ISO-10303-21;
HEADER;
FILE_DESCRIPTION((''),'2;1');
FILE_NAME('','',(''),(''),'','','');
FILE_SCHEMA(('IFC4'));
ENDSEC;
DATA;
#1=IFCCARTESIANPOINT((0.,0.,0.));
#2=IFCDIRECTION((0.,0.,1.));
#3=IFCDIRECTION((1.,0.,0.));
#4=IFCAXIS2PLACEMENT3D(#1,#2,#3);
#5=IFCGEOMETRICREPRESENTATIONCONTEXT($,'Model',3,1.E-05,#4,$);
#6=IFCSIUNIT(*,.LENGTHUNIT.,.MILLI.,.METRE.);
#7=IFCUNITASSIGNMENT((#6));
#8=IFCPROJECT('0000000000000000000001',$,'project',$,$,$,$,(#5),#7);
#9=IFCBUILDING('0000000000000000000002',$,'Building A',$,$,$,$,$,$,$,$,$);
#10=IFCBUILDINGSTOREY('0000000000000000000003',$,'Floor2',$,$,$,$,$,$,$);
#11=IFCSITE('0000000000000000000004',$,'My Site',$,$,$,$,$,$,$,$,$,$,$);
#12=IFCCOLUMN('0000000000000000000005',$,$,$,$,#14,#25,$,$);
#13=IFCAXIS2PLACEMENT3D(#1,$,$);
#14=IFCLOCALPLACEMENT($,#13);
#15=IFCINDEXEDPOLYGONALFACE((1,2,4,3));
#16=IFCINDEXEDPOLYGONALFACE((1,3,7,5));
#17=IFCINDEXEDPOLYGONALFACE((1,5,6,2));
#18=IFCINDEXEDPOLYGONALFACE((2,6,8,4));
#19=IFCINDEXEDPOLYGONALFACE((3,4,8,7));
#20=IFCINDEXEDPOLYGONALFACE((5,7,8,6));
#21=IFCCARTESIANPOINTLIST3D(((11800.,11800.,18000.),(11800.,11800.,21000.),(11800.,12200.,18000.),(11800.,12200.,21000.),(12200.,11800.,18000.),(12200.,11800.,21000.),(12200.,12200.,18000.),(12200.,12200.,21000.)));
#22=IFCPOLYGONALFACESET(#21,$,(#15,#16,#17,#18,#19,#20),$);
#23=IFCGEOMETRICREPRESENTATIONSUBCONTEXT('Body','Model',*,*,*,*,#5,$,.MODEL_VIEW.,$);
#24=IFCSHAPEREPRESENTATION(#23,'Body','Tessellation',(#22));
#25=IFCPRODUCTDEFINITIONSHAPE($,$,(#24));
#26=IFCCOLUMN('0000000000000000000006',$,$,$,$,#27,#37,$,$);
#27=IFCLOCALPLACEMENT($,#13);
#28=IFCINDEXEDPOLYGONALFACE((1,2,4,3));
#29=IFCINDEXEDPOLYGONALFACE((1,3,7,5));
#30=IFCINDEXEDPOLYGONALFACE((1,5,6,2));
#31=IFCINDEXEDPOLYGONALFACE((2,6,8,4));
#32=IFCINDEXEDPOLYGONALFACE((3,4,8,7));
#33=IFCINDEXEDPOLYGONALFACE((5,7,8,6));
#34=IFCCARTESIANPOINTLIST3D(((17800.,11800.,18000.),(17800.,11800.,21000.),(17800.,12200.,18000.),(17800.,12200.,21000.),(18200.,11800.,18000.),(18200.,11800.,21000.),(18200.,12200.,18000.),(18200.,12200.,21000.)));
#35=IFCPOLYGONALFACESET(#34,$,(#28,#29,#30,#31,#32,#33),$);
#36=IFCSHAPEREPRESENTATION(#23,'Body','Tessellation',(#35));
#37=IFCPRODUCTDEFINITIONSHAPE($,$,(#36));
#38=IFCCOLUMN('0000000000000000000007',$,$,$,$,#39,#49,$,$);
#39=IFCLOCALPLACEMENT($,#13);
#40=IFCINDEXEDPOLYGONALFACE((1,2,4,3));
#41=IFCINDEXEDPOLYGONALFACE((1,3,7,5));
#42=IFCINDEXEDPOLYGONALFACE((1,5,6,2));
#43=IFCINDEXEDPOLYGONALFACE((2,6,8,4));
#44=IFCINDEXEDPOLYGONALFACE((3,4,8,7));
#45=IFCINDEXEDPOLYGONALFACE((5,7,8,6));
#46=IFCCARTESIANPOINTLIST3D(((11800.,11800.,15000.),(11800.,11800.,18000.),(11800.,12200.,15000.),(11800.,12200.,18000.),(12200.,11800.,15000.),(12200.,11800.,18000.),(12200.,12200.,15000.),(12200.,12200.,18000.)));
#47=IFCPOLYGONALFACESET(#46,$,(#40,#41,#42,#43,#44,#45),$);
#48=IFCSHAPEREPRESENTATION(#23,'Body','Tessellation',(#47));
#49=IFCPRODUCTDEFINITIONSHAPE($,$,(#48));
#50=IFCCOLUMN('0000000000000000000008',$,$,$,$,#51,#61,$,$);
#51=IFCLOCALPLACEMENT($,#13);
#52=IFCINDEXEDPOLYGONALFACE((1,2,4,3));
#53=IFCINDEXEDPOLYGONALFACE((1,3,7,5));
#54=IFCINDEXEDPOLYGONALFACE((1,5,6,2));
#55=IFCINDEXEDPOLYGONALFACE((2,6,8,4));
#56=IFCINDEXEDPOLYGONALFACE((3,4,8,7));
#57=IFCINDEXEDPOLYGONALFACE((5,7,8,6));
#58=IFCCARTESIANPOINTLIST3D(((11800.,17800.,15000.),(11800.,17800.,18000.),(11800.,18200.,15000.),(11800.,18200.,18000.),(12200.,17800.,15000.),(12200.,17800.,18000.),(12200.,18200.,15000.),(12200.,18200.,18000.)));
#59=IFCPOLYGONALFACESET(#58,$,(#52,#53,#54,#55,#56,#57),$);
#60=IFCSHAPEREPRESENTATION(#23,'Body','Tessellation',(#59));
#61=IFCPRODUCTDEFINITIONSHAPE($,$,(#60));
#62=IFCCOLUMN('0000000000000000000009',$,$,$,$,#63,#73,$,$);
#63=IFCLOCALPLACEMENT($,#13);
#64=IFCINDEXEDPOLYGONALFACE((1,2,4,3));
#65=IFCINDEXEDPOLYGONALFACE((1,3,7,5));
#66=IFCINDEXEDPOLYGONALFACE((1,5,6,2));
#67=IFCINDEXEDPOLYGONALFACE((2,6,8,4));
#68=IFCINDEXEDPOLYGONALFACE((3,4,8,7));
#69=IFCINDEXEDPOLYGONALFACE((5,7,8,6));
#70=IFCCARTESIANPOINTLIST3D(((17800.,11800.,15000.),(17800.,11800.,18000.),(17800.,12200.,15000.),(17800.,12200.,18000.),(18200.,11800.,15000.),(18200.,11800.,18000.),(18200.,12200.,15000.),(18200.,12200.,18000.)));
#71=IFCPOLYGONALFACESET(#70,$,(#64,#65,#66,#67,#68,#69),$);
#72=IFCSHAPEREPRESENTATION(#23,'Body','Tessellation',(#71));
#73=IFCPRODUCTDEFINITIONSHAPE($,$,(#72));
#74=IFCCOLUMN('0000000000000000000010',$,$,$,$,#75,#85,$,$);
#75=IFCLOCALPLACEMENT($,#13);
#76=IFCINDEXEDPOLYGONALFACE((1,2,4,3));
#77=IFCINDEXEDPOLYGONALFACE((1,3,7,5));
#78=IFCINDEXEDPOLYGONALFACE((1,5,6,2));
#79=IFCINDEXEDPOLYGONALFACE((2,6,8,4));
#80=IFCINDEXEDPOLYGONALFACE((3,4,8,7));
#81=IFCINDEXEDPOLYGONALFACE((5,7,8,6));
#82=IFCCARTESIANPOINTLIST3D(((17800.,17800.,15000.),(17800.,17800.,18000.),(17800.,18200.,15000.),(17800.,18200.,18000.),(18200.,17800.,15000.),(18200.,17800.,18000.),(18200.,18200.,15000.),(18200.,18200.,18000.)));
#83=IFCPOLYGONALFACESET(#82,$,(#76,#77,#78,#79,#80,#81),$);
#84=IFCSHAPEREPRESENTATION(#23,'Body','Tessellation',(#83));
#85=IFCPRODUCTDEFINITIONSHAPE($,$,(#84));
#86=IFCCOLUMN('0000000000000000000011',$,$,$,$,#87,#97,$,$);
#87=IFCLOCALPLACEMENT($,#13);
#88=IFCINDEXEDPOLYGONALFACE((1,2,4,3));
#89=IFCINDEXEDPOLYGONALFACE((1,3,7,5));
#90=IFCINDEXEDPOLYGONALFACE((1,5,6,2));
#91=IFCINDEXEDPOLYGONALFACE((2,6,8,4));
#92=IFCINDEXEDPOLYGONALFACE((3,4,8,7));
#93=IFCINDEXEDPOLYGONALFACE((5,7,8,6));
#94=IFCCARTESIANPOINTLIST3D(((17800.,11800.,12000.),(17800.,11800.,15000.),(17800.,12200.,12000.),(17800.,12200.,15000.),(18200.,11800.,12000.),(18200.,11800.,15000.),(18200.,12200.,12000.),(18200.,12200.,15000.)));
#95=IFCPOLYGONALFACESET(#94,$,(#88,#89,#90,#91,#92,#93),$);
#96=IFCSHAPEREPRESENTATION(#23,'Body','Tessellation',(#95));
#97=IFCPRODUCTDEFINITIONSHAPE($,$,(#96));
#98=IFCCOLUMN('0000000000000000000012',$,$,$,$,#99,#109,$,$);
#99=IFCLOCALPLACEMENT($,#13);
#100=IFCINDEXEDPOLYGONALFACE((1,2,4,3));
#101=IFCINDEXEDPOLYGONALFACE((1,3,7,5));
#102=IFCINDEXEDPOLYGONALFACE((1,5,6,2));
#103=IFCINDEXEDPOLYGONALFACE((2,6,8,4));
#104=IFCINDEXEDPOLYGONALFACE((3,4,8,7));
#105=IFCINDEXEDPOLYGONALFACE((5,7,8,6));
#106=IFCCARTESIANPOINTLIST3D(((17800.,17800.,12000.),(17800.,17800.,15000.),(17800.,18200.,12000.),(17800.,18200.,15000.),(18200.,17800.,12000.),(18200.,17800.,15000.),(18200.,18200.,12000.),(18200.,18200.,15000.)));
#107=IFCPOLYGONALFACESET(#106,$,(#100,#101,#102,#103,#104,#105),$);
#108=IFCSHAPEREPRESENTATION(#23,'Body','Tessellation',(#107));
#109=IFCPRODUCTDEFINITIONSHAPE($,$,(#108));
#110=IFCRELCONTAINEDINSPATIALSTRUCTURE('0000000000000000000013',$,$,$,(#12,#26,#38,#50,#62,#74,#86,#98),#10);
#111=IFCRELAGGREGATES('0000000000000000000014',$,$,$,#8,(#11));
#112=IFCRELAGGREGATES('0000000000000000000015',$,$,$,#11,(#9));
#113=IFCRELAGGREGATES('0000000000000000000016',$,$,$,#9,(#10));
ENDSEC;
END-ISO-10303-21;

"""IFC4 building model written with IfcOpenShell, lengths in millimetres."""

from ifc_helpers import new_model, si_unit, frame, origin_with_axes, place, context, subcontext, project, spatial, line, indexed_curve, outline, extrude, element, save


model = new_model("IFC4")

# Units and contexts
model_context = context("Model", 3, precision=1e-05, world=origin_with_axes())
body_context = subcontext(model_context, "Body", "Model", "MODEL_VIEW")
ifc_project = project(units=[si_unit("LENGTHUNIT", "METRE", prefix="MILLI")], contexts=[model_context])

# Site, building, storey
site = spatial("IfcSite", under=ifc_project, Name="My Site")
building = spatial("IfcBuilding", under=site, Name="Building A")
storey = spatial("IfcBuildingStorey", under=building, Name="Floor2")

# Columns
for number, where, z_axis, x_axis in (
    (1, (12000.0, 12000.0, 18000.0), (0.0, 0.0, 1.0), (1.0, 0.0, 0.0)),
    (2, (18000.0, 12000.0, 18000.0), (0.0, 0.0, 1.0), (1.0, 0.0, 0.0)),
    (3, (12000.0, 12000.0, 15000.0), (0.0, 0.0, 1.0), (1.0, 0.0, 0.0)),
    (4, (12000.0, 18000.0, 15000.0), (0.0, 0.0, 1.0), (1.0, 0.0, 0.0)),
    (5, (18000.0, 12000.0, 15000.0), (0.0, 0.0, 1.0), (1.0, 0.0, 0.0)),
    (6, (18000.0, 18000.0, 15000.0), (0.0, 0.0, 1.0), (1.0, 0.0, 0.0)),
    (7, (18000.0, 12000.0, 12000.0), (0.0, 0.0, 1.0), (1.0, 0.0, 0.0)),
    (8, (18000.0, 18000.0, 12000.0), (0.0, 0.0, 1.0), (1.0, 0.0, 0.0)),
):
    element("IfcColumn", number, at=place(None, frame(where, z_axis=z_axis, x_axis=x_axis)), inside=storey, context=body_context, shape_type="SweptSolid", body=[
        extrude(outline(indexed_curve([(-200.0, -200.0), (200.0, -200.0), (200.0, 200.0), (-200.0, 200.0)], segments=[line(1, 2, 3, 4, 1)])), origin_with_axes(), (0.0, 0.0, 1.0), 3000.0),
    ])

save(model, "model.ifc")
